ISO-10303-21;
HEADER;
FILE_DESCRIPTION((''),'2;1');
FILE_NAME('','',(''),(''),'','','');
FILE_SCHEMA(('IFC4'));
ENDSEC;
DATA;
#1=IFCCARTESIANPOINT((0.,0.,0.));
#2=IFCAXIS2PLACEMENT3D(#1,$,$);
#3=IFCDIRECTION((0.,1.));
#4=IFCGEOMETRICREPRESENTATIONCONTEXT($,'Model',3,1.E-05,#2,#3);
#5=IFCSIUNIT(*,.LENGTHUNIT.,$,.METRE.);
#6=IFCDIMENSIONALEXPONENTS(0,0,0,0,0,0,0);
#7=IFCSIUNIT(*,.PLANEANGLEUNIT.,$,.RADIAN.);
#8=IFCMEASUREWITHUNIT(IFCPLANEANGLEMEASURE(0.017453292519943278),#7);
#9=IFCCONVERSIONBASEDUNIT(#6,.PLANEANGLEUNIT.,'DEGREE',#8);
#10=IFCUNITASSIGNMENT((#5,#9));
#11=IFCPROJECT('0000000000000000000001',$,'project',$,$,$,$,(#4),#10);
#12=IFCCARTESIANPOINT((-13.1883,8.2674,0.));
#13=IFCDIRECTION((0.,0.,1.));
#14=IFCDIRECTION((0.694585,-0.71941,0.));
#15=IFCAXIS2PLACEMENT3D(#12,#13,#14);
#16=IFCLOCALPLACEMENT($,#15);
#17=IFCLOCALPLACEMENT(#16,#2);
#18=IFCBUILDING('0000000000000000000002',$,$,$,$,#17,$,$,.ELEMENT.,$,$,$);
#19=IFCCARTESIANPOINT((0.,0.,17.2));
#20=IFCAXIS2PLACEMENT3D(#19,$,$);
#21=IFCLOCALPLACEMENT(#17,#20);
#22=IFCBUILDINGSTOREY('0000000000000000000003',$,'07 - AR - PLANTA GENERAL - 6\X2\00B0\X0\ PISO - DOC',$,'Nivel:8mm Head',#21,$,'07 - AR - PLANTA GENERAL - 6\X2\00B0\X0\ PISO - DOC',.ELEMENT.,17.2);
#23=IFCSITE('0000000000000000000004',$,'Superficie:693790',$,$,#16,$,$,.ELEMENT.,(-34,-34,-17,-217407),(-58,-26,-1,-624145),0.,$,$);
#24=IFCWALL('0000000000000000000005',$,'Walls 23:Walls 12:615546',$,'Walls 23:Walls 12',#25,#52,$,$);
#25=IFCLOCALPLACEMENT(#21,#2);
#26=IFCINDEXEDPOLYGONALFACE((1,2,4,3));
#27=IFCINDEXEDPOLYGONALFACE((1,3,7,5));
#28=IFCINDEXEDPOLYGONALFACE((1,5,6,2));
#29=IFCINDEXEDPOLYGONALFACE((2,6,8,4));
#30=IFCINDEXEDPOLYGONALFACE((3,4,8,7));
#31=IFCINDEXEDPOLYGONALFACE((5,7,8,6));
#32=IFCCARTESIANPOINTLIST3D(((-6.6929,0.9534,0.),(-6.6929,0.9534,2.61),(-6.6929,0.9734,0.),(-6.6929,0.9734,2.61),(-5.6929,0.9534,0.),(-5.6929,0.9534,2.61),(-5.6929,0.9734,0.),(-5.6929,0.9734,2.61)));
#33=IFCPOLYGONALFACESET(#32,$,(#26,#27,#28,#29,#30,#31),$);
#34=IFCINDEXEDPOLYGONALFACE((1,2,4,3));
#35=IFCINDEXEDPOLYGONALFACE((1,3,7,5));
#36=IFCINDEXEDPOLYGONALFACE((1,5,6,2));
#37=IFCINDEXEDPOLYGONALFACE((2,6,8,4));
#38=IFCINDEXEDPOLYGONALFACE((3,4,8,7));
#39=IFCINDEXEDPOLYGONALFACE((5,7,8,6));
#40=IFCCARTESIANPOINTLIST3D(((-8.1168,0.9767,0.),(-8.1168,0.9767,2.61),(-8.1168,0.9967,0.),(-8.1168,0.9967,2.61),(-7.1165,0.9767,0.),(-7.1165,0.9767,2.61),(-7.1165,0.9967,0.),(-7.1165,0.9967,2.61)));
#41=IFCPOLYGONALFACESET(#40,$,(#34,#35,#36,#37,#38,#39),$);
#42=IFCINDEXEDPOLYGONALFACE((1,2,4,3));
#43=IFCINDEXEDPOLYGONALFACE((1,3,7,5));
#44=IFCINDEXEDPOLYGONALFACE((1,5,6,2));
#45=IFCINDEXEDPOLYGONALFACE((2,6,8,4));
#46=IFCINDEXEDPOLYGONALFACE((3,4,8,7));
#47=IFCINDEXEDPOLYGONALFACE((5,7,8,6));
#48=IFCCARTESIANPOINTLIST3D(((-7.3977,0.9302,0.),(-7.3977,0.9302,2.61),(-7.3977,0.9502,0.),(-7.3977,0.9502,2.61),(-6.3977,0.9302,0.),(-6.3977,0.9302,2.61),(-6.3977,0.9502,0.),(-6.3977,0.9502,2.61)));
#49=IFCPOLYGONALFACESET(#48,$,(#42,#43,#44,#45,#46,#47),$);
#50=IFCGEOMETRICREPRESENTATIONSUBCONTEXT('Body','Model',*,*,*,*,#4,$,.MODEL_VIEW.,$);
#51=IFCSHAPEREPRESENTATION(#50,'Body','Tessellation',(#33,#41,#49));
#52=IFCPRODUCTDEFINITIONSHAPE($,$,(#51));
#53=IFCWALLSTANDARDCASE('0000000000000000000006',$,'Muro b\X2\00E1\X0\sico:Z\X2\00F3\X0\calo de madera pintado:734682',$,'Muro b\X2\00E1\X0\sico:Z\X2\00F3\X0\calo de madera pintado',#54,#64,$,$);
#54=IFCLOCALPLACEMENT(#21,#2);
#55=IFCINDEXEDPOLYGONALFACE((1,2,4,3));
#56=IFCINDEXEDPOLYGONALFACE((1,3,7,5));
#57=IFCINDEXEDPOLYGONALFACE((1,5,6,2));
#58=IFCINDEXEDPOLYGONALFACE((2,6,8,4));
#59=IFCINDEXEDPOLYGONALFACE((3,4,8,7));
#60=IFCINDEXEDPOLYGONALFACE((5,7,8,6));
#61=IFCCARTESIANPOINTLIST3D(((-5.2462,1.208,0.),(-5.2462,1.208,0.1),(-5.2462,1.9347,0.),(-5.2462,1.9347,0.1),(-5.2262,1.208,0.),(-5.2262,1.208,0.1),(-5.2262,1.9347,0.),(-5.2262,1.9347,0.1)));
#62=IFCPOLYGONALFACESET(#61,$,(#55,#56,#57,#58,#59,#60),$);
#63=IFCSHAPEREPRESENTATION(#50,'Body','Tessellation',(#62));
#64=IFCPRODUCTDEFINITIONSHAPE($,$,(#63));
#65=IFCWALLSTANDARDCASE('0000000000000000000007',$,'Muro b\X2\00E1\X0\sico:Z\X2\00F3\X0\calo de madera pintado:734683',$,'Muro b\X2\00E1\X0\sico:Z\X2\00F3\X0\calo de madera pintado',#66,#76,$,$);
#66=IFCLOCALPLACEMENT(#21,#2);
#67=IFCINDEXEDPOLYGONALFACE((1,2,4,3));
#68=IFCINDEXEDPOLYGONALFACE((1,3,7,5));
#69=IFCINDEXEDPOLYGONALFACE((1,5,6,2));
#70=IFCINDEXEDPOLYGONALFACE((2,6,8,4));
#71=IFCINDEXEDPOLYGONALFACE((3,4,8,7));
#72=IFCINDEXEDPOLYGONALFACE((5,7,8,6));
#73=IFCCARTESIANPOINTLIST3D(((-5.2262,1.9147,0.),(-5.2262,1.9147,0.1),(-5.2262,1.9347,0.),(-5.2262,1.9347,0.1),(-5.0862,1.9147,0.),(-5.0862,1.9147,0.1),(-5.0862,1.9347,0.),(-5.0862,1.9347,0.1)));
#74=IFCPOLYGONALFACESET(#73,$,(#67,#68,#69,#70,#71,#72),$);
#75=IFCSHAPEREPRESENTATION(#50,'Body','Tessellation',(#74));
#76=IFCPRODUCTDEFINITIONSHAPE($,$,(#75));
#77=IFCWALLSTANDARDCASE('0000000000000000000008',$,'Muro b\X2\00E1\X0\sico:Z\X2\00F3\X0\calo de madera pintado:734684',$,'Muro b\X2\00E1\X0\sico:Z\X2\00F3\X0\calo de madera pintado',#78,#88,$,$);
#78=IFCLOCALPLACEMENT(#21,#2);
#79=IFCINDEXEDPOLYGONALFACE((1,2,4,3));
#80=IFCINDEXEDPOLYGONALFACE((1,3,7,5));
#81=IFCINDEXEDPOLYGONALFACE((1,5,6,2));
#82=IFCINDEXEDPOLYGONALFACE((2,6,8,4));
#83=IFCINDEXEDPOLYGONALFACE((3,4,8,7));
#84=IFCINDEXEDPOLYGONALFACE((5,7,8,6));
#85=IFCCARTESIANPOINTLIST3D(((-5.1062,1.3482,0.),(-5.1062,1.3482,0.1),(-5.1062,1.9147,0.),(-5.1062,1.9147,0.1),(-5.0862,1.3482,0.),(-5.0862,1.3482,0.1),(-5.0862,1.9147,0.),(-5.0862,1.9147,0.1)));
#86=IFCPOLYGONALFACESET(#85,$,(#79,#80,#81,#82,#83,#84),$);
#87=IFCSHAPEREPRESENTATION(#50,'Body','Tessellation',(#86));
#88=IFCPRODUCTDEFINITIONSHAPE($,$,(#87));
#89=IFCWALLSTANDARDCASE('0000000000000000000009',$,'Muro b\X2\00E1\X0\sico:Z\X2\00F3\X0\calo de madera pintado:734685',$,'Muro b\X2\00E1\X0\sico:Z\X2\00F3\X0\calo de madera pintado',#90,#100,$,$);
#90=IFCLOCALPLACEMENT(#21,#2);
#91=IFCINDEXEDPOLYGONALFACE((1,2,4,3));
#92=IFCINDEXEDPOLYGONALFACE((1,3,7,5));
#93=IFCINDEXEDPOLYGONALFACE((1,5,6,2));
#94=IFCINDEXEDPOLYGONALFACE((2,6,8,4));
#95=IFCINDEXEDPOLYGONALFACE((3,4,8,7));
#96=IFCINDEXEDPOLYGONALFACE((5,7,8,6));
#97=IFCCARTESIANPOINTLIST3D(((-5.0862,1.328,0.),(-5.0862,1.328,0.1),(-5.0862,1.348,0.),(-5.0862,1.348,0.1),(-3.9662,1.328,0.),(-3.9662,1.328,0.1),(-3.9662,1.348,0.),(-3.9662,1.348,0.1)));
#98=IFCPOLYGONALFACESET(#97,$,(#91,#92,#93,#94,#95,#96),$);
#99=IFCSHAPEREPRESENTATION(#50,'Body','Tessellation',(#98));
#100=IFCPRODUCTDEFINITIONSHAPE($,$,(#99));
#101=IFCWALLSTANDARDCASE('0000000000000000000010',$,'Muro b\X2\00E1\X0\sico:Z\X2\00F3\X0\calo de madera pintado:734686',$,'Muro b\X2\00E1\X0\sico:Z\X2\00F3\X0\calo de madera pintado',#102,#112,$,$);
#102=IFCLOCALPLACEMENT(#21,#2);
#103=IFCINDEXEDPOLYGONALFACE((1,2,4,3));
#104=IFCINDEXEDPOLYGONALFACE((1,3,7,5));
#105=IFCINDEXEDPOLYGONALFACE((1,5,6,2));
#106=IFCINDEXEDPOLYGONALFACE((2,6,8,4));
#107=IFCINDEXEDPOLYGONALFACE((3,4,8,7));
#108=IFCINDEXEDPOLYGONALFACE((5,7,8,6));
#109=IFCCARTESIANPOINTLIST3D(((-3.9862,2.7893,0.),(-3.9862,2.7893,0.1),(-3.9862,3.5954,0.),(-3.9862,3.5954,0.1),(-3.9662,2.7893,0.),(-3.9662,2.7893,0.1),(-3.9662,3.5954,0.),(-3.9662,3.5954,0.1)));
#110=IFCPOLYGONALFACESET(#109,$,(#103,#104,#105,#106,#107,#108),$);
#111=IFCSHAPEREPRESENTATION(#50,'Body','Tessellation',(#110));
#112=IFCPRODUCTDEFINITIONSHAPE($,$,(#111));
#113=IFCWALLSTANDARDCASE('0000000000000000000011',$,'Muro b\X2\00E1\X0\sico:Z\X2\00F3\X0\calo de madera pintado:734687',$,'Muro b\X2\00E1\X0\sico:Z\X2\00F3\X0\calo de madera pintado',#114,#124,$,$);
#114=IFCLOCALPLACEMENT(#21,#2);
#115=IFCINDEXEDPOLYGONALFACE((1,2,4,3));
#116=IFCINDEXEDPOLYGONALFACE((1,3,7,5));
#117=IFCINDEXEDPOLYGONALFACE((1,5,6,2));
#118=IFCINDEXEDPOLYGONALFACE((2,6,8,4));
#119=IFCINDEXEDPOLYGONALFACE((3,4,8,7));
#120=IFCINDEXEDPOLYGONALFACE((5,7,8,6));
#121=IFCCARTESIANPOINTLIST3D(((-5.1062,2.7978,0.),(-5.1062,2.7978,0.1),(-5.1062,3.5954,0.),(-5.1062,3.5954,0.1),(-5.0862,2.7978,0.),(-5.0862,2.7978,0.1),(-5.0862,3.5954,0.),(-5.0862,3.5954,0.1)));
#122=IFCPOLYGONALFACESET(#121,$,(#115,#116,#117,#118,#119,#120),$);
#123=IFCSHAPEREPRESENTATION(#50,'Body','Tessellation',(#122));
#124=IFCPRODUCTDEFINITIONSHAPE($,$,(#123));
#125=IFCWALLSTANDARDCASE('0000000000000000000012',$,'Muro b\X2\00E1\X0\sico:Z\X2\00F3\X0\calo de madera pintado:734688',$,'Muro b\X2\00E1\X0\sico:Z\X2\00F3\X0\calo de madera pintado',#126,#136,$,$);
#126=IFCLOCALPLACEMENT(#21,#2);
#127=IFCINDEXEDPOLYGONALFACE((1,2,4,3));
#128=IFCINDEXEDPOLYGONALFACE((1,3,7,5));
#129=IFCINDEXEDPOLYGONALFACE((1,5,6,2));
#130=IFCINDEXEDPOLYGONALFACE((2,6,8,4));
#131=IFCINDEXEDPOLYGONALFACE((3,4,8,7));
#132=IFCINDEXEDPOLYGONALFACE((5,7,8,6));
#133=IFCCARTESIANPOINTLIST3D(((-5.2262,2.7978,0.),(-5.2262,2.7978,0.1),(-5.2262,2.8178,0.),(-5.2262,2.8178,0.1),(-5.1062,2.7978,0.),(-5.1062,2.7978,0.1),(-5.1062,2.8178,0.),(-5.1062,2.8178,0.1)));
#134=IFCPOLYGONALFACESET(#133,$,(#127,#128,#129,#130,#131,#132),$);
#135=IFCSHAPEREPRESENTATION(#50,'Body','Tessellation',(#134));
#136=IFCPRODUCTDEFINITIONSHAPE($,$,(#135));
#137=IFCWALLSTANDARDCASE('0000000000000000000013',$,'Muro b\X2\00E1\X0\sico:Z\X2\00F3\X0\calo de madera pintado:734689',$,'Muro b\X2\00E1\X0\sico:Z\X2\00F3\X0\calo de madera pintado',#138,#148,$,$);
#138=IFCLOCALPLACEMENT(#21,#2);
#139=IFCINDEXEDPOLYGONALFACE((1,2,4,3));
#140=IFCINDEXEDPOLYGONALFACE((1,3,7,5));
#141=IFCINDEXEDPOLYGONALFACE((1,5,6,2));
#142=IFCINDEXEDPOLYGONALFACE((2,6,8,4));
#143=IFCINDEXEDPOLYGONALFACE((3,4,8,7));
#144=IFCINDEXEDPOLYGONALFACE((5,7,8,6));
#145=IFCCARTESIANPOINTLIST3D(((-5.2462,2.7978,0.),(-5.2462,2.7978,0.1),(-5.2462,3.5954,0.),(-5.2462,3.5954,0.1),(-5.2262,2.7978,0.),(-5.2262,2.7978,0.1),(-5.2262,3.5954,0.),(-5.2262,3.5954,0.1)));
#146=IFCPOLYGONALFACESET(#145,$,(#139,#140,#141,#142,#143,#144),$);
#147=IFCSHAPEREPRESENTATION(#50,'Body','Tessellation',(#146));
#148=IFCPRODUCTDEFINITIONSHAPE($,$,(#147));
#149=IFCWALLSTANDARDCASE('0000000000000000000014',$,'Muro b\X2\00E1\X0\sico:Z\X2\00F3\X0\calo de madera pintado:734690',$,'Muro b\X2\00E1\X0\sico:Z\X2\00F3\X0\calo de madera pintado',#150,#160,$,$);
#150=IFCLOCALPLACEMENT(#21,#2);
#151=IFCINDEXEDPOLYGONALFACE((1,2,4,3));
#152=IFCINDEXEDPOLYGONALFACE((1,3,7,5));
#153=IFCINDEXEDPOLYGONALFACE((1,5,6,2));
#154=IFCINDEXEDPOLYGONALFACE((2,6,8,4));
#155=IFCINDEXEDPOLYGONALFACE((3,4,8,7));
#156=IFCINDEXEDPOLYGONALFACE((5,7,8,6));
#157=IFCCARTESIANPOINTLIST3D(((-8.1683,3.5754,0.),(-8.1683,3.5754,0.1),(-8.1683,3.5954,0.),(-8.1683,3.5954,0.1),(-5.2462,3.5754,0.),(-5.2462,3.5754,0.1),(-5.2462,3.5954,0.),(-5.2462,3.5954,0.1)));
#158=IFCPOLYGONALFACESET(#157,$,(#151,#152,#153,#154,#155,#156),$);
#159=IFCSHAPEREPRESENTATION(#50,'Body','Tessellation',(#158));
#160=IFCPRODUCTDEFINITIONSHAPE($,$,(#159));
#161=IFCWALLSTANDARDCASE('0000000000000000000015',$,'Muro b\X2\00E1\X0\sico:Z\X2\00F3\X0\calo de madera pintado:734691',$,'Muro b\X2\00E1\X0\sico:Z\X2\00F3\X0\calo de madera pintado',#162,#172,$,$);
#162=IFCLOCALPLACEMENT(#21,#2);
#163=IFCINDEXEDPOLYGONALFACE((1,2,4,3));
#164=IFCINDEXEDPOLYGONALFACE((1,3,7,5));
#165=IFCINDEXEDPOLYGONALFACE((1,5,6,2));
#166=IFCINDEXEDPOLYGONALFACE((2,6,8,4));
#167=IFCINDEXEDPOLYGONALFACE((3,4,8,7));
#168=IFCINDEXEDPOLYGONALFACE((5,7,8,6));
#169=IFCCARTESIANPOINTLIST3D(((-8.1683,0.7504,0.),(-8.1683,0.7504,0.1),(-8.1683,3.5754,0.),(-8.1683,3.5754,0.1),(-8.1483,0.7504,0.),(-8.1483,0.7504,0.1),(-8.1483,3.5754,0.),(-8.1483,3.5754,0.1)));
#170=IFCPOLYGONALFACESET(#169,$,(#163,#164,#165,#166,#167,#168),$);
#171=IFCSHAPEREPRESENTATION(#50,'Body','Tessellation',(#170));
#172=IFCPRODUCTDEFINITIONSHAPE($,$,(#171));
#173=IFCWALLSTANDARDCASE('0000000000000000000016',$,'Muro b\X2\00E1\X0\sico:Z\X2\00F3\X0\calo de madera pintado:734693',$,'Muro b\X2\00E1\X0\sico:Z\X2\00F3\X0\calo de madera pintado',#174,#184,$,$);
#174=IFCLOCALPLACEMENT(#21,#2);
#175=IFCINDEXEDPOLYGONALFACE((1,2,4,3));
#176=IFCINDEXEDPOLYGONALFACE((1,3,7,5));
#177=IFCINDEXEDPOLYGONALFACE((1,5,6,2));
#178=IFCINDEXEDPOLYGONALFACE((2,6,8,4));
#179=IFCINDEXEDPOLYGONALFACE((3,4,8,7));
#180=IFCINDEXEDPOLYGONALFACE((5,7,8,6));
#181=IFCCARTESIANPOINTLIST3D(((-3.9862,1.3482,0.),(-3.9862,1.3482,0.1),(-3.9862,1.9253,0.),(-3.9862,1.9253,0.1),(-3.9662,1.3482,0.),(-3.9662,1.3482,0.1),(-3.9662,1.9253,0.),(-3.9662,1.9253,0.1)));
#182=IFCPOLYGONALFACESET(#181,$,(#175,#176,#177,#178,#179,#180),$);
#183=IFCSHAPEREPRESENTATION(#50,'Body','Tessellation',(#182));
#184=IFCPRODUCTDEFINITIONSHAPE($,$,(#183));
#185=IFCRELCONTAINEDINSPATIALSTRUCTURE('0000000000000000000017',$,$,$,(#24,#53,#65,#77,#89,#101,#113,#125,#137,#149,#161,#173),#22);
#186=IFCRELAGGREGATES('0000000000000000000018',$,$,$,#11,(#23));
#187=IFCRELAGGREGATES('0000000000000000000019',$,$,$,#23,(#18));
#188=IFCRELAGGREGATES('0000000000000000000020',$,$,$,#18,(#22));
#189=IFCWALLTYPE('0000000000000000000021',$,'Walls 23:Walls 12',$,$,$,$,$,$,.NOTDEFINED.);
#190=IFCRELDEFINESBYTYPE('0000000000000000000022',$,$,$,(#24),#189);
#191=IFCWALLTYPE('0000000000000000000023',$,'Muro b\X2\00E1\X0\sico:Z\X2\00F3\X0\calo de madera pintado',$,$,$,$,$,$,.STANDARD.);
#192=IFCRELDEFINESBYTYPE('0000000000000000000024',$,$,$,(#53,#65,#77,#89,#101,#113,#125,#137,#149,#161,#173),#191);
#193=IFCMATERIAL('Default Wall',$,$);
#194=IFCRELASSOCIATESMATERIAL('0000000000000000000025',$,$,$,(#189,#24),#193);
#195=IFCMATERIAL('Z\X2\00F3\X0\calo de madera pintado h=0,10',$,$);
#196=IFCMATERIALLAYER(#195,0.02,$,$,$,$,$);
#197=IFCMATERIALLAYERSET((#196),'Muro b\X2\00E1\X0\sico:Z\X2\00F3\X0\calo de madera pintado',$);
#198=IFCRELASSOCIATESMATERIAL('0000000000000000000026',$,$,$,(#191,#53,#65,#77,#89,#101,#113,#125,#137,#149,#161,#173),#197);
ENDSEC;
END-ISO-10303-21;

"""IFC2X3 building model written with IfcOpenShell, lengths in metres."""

from ifc_helpers import new_model, entity, si_unit, converted_unit, direction, frame, frame_2d, origin, origin_2d_with_axis, place, context, subcontext, project, spatial, rectangle, extrude, material, layer, layer_set, layer_usage, type_object, element, save


model = new_model("IFC2X3")

# Units and contexts
model_context = context("Model", 3, precision=1e-05, world=origin(), true_north=direction((0.0, 1.0)))
body_context = subcontext(model_context, "Body", "Model", "MODEL_VIEW")
ifc_project = project(units=[si_unit("LENGTHUNIT", "METRE"), converted_unit("PLANEANGLEUNIT", "DEGREE", entity("IfcPlaneAngleMeasure", 0.017453292519943278), si_unit("PLANEANGLEUNIT", "RADIAN"), dimensions=[0, 0, 0, 0, 0, 0, 0])], contexts=[model_context])

# Site, building, storey
site_placement = place(None, frame((-13.1883, 8.2674, 0.0), z_axis=(0.0, 0.0, 1.0), x_axis=(0.694585, -0.71941, 0.0)))
site = spatial("IfcSite", under=ifc_project, at=site_placement, Name="Superficie:693790", CompositionType="ELEMENT", RefLatitude=(-34, -34, -17, -217407), RefLongitude=(-58, -26, -1, -624145), RefElevation=0.0)
building_placement = place(site_placement, origin())
building = spatial("IfcBuilding", under=site, at=building_placement, CompositionType="ELEMENT")
storey_placement = place(building_placement, frame((0.0, 0.0, 17.2)))
storey = spatial("IfcBuildingStorey", under=building, at=storey_placement, Name="07 - AR - PLANTA GENERAL - 6° PISO - DOC", ObjectType="Nivel:8mm Head", LongName="07 - AR - PLANTA GENERAL - 6° PISO - DOC", CompositionType="ELEMENT", Elevation=17.2)

# Walls
ifc_material_1 = material(Name="Default Wall")
wall_type_1 = type_object("IfcWallType", Name="Walls 23:Walls 12", PredefinedType="NOTDEFINED", material=ifc_material_1)
wall_1_placement = place(storey_placement, frame((-8.1168, 0.9302, 0.0)))
element("IfcWall", 1, at=wall_1_placement, inside=storey, type_object=wall_type_1, material=ifc_material_1, Name="Walls 23:Walls 12:615546", ObjectType="Walls 23:Walls 12", context=body_context, shape_type="SweptSolid", body=[
    extrude(rectangle(XDim=1.0, YDim=0.02, at=origin_2d_with_axis()), frame((1.9239, 0.0332, 0.0), z_axis=(0.0, 0.0, 1.0), x_axis=(-1.0, 0.0, 0.0)), (0.0, 0.0, 1.0), 2.61),
    extrude(rectangle(XDim=1.0003, YDim=0.02, at=origin_2d_with_axis()), frame((0.5001, 0.0565, 0.0), z_axis=(0.0, 0.0, 1.0), x_axis=(-1.0, 0.0, 0.0)), (0.0, 0.0, 1.0), 2.61),
    extrude(rectangle(XDim=1.0, YDim=0.02, at=origin_2d_with_axis()), frame((1.2191, 0.01, 0.0), z_axis=(0.0, 0.0, 1.0), x_axis=(-1.0, 0.0, 0.0)), (0.0, 0.0, 1.0), 2.61),
])
ifc_material_2 = material(Name="Zócalo de madera pintado h=0,10")
ifc_layer_1 = layer(ifc_material_2, 0.02)
ifc_layer_set_1 = layer_set([ifc_layer_1], Name="Muro básico:Zócalo de madera pintado")
ifc_layer_usage_1 = layer_usage(ifc_layer_set_1, "AXIS2", "NEGATIVE", 0.01)
wall_type_2 = type_object("IfcWallType", Name="Muro básico:Zócalo de madera pintado", PredefinedType="STANDARD", material=ifc_layer_set_1)
wall_2_placement = place(storey_placement, frame((-5.2362, 1.208, 0.0), z_axis=(0.0, 0.0, 1.0), x_axis=(0.0, 1.0, 0.0)))
element("IfcWallStandardCase", 2, at=wall_2_placement, inside=storey, type_object=wall_type_2, material=ifc_layer_usage_1, Name="Muro básico:Zócalo de madera pintado:734682", ObjectType="Muro básico:Zócalo de madera pintado", context=body_context, shape_type="SweptSolid", body=[
    extrude(rectangle(XDim=0.7266, YDim=0.02, at=frame_2d((0.3633, 0.0), x_axis=(-1.0, 0.0))), origin(), (0.0, 0.0, 1.0), 0.1),
])
ifc_layer_usage_2 = layer_usage(ifc_layer_set_1, "AXIS2", "NEGATIVE", 0.01)
wall_3_placement = place(storey_placement, frame((-5.2262, 1.9247, 0.0)))
element("IfcWallStandardCase", 3, at=wall_3_placement, inside=storey, type_object=wall_type_2, material=ifc_layer_usage_2, Name="Muro básico:Zócalo de madera pintado:734683", ObjectType="Muro básico:Zócalo de madera pintado", context=body_context, shape_type="SweptSolid", body=[
    extrude(rectangle(XDim=0.14, YDim=0.02, at=frame_2d((0.07, 0.0), x_axis=(-1.0, 0.0))), origin(), (0.0, 0.0, 1.0), 0.1),
])
ifc_layer_usage_3 = layer_usage(ifc_layer_set_1, "AXIS2", "NEGATIVE", 0.01)
wall_4_placement = place(storey_placement, frame((-5.0962, 1.9147, 0.0), z_axis=(0.0, 0.0, 1.0), x_axis=(0.0, -1.0, 0.0)))
element("IfcWallStandardCase", 4, at=wall_4_placement, inside=storey, type_object=wall_type_2, material=ifc_layer_usage_3, Name="Muro básico:Zócalo de madera pintado:734684", ObjectType="Muro básico:Zócalo de madera pintado", context=body_context, shape_type="SweptSolid", body=[
    extrude(rectangle(XDim=0.5665, YDim=0.02, at=frame_2d((0.2833, 0.0), x_axis=(-1.0, 0.0))), origin(), (0.0, 0.0, 1.0), 0.1),
])
ifc_layer_usage_4 = layer_usage(ifc_layer_set_1, "AXIS2", "NEGATIVE", 0.01)
wall_5_placement = place(storey_placement, frame((-5.0862, 1.338, 0.0)))
element("IfcWallStandardCase", 5, at=wall_5_placement, inside=storey, type_object=wall_type_2, material=ifc_layer_usage_4, Name="Muro básico:Zócalo de madera pintado:734685", ObjectType="Muro básico:Zócalo de madera pintado", context=body_context, shape_type="SweptSolid", body=[
    extrude(rectangle(XDim=1.12, YDim=0.02, at=frame_2d((0.56, 0.0), x_axis=(-1.0, 0.0))), origin(), (0.0, 0.0, 1.0), 0.1),
])
ifc_layer_usage_5 = layer_usage(ifc_layer_set_1, "AXIS2", "NEGATIVE", 0.01)
wall_6_placement = place(storey_placement, frame((-3.9762, 2.7893, 0.0), z_axis=(0.0, 0.0, 1.0), x_axis=(0.0, 1.0, 0.0)))
element("IfcWallStandardCase", 6, at=wall_6_placement, inside=storey, type_object=wall_type_2, material=ifc_layer_usage_5, Name="Muro básico:Zócalo de madera pintado:734686", ObjectType="Muro básico:Zócalo de madera pintado", context=body_context, shape_type="SweptSolid", body=[
    extrude(rectangle(XDim=0.8061, YDim=0.02, at=frame_2d((0.4031, 0.0), x_axis=(-1.0, 0.0))), origin(), (0.0, 0.0, 1.0), 0.1),
])
ifc_layer_usage_6 = layer_usage(ifc_layer_set_1, "AXIS2", "NEGATIVE", 0.01)
wall_7_placement = place(storey_placement, frame((-5.0962, 3.5954, 0.0), z_axis=(0.0, 0.0, 1.0), x_axis=(0.0, -1.0, 0.0)))
element("IfcWallStandardCase", 7, at=wall_7_placement, inside=storey, type_object=wall_type_2, material=ifc_layer_usage_6, Name="Muro básico:Zócalo de madera pintado:734687", ObjectType="Muro básico:Zócalo de madera pintado", context=body_context, shape_type="SweptSolid", body=[
    extrude(rectangle(XDim=0.7977, YDim=0.02, at=frame_2d((0.3988, 0.0), x_axis=(-1.0, 0.0))), origin(), (0.0, 0.0, 1.0), 0.1),
])
ifc_layer_usage_7 = layer_usage(ifc_layer_set_1, "AXIS2", "NEGATIVE", 0.01)
wall_8_placement = place(storey_placement, frame((-5.1062, 2.8078, 0.0), z_axis=(0.0, 0.0, 1.0), x_axis=(-1.0, 0.0, 0.0)))
element("IfcWallStandardCase", 8, at=wall_8_placement, inside=storey, type_object=wall_type_2, material=ifc_layer_usage_7, Name="Muro básico:Zócalo de madera pintado:734688", ObjectType="Muro básico:Zócalo de madera pintado", context=body_context, shape_type="SweptSolid", body=[
    extrude(rectangle(XDim=0.12, YDim=0.02, at=frame_2d((0.06, 0.0), x_axis=(-1.0, 0.0))), origin(), (0.0, 0.0, 1.0), 0.1),
])
ifc_layer_usage_8 = layer_usage(ifc_layer_set_1, "AXIS2", "NEGATIVE", 0.01)
wall_9_placement = place(storey_placement, frame((-5.2362, 2.7978, 0.0), z_axis=(0.0, 0.0, 1.0), x_axis=(0.0, 1.0, 0.0)))
element("IfcWallStandardCase", 9, at=wall_9_placement, inside=storey, type_object=wall_type_2, material=ifc_layer_usage_8, Name="Muro básico:Zócalo de madera pintado:734689", ObjectType="Muro básico:Zócalo de madera pintado", context=body_context, shape_type="SweptSolid", body=[
    extrude(rectangle(XDim=0.7977, YDim=0.02, at=frame_2d((0.3988, 0.0), x_axis=(-1.0, 0.0))), origin(), (0.0, 0.0, 1.0), 0.1),
])
ifc_layer_usage_9 = layer_usage(ifc_layer_set_1, "AXIS2", "NEGATIVE", 0.01)
wall_10_placement = place(storey_placement, frame((-5.2462, 3.5854, 0.0), z_axis=(0.0, 0.0, 1.0), x_axis=(-1.0, 0.0, 0.0)))
element("IfcWallStandardCase", 10, at=wall_10_placement, inside=storey, type_object=wall_type_2, material=ifc_layer_usage_9, Name="Muro básico:Zócalo de madera pintado:734690", ObjectType="Muro básico:Zócalo de madera pintado", context=body_context, shape_type="SweptSolid", body=[
    extrude(rectangle(XDim=2.922, YDim=0.02, at=frame_2d((1.461, 0.0), x_axis=(-1.0, 0.0))), origin(), (0.0, 0.0, 1.0), 0.1),
])
ifc_layer_usage_10 = layer_usage(ifc_layer_set_1, "AXIS2", "NEGATIVE", 0.01)
wall_11_placement = place(storey_placement, frame((-8.1583, 3.5754, 0.0), z_axis=(0.0, 0.0, 1.0), x_axis=(0.0, -1.0, 0.0)))
element("IfcWallStandardCase", 11, at=wall_11_placement, inside=storey, type_object=wall_type_2, material=ifc_layer_usage_10, Name="Muro básico:Zócalo de madera pintado:734691", ObjectType="Muro básico:Zócalo de madera pintado", context=body_context, shape_type="SweptSolid", body=[
    extrude(rectangle(XDim=2.825, YDim=0.02, at=frame_2d((1.4125, 0.0), x_axis=(-1.0, 0.0))), origin(), (0.0, 0.0, 1.0), 0.1),
])

# Wall
ifc_layer_usage_11 = layer_usage(ifc_layer_set_1, "AXIS2", "NEGATIVE", 0.01)
wall_12_placement = place(storey_placement, frame((-3.9762, 1.3482, 0.0), z_axis=(0.0, 0.0, 1.0), x_axis=(0.0, 1.0, 0.0)))
element("IfcWallStandardCase", 12, at=wall_12_placement, inside=storey, type_object=wall_type_2, material=ifc_layer_usage_11, Name="Muro básico:Zócalo de madera pintado:734693", ObjectType="Muro básico:Zócalo de madera pintado", context=body_context, shape_type="SweptSolid", body=[
    extrude(rectangle(XDim=0.5771, YDim=0.02, at=frame_2d((0.2886, 0.0), x_axis=(-1.0, 0.0))), origin(), (0.0, 0.0, 1.0), 0.1),
])

save(model, "model.ifc")
